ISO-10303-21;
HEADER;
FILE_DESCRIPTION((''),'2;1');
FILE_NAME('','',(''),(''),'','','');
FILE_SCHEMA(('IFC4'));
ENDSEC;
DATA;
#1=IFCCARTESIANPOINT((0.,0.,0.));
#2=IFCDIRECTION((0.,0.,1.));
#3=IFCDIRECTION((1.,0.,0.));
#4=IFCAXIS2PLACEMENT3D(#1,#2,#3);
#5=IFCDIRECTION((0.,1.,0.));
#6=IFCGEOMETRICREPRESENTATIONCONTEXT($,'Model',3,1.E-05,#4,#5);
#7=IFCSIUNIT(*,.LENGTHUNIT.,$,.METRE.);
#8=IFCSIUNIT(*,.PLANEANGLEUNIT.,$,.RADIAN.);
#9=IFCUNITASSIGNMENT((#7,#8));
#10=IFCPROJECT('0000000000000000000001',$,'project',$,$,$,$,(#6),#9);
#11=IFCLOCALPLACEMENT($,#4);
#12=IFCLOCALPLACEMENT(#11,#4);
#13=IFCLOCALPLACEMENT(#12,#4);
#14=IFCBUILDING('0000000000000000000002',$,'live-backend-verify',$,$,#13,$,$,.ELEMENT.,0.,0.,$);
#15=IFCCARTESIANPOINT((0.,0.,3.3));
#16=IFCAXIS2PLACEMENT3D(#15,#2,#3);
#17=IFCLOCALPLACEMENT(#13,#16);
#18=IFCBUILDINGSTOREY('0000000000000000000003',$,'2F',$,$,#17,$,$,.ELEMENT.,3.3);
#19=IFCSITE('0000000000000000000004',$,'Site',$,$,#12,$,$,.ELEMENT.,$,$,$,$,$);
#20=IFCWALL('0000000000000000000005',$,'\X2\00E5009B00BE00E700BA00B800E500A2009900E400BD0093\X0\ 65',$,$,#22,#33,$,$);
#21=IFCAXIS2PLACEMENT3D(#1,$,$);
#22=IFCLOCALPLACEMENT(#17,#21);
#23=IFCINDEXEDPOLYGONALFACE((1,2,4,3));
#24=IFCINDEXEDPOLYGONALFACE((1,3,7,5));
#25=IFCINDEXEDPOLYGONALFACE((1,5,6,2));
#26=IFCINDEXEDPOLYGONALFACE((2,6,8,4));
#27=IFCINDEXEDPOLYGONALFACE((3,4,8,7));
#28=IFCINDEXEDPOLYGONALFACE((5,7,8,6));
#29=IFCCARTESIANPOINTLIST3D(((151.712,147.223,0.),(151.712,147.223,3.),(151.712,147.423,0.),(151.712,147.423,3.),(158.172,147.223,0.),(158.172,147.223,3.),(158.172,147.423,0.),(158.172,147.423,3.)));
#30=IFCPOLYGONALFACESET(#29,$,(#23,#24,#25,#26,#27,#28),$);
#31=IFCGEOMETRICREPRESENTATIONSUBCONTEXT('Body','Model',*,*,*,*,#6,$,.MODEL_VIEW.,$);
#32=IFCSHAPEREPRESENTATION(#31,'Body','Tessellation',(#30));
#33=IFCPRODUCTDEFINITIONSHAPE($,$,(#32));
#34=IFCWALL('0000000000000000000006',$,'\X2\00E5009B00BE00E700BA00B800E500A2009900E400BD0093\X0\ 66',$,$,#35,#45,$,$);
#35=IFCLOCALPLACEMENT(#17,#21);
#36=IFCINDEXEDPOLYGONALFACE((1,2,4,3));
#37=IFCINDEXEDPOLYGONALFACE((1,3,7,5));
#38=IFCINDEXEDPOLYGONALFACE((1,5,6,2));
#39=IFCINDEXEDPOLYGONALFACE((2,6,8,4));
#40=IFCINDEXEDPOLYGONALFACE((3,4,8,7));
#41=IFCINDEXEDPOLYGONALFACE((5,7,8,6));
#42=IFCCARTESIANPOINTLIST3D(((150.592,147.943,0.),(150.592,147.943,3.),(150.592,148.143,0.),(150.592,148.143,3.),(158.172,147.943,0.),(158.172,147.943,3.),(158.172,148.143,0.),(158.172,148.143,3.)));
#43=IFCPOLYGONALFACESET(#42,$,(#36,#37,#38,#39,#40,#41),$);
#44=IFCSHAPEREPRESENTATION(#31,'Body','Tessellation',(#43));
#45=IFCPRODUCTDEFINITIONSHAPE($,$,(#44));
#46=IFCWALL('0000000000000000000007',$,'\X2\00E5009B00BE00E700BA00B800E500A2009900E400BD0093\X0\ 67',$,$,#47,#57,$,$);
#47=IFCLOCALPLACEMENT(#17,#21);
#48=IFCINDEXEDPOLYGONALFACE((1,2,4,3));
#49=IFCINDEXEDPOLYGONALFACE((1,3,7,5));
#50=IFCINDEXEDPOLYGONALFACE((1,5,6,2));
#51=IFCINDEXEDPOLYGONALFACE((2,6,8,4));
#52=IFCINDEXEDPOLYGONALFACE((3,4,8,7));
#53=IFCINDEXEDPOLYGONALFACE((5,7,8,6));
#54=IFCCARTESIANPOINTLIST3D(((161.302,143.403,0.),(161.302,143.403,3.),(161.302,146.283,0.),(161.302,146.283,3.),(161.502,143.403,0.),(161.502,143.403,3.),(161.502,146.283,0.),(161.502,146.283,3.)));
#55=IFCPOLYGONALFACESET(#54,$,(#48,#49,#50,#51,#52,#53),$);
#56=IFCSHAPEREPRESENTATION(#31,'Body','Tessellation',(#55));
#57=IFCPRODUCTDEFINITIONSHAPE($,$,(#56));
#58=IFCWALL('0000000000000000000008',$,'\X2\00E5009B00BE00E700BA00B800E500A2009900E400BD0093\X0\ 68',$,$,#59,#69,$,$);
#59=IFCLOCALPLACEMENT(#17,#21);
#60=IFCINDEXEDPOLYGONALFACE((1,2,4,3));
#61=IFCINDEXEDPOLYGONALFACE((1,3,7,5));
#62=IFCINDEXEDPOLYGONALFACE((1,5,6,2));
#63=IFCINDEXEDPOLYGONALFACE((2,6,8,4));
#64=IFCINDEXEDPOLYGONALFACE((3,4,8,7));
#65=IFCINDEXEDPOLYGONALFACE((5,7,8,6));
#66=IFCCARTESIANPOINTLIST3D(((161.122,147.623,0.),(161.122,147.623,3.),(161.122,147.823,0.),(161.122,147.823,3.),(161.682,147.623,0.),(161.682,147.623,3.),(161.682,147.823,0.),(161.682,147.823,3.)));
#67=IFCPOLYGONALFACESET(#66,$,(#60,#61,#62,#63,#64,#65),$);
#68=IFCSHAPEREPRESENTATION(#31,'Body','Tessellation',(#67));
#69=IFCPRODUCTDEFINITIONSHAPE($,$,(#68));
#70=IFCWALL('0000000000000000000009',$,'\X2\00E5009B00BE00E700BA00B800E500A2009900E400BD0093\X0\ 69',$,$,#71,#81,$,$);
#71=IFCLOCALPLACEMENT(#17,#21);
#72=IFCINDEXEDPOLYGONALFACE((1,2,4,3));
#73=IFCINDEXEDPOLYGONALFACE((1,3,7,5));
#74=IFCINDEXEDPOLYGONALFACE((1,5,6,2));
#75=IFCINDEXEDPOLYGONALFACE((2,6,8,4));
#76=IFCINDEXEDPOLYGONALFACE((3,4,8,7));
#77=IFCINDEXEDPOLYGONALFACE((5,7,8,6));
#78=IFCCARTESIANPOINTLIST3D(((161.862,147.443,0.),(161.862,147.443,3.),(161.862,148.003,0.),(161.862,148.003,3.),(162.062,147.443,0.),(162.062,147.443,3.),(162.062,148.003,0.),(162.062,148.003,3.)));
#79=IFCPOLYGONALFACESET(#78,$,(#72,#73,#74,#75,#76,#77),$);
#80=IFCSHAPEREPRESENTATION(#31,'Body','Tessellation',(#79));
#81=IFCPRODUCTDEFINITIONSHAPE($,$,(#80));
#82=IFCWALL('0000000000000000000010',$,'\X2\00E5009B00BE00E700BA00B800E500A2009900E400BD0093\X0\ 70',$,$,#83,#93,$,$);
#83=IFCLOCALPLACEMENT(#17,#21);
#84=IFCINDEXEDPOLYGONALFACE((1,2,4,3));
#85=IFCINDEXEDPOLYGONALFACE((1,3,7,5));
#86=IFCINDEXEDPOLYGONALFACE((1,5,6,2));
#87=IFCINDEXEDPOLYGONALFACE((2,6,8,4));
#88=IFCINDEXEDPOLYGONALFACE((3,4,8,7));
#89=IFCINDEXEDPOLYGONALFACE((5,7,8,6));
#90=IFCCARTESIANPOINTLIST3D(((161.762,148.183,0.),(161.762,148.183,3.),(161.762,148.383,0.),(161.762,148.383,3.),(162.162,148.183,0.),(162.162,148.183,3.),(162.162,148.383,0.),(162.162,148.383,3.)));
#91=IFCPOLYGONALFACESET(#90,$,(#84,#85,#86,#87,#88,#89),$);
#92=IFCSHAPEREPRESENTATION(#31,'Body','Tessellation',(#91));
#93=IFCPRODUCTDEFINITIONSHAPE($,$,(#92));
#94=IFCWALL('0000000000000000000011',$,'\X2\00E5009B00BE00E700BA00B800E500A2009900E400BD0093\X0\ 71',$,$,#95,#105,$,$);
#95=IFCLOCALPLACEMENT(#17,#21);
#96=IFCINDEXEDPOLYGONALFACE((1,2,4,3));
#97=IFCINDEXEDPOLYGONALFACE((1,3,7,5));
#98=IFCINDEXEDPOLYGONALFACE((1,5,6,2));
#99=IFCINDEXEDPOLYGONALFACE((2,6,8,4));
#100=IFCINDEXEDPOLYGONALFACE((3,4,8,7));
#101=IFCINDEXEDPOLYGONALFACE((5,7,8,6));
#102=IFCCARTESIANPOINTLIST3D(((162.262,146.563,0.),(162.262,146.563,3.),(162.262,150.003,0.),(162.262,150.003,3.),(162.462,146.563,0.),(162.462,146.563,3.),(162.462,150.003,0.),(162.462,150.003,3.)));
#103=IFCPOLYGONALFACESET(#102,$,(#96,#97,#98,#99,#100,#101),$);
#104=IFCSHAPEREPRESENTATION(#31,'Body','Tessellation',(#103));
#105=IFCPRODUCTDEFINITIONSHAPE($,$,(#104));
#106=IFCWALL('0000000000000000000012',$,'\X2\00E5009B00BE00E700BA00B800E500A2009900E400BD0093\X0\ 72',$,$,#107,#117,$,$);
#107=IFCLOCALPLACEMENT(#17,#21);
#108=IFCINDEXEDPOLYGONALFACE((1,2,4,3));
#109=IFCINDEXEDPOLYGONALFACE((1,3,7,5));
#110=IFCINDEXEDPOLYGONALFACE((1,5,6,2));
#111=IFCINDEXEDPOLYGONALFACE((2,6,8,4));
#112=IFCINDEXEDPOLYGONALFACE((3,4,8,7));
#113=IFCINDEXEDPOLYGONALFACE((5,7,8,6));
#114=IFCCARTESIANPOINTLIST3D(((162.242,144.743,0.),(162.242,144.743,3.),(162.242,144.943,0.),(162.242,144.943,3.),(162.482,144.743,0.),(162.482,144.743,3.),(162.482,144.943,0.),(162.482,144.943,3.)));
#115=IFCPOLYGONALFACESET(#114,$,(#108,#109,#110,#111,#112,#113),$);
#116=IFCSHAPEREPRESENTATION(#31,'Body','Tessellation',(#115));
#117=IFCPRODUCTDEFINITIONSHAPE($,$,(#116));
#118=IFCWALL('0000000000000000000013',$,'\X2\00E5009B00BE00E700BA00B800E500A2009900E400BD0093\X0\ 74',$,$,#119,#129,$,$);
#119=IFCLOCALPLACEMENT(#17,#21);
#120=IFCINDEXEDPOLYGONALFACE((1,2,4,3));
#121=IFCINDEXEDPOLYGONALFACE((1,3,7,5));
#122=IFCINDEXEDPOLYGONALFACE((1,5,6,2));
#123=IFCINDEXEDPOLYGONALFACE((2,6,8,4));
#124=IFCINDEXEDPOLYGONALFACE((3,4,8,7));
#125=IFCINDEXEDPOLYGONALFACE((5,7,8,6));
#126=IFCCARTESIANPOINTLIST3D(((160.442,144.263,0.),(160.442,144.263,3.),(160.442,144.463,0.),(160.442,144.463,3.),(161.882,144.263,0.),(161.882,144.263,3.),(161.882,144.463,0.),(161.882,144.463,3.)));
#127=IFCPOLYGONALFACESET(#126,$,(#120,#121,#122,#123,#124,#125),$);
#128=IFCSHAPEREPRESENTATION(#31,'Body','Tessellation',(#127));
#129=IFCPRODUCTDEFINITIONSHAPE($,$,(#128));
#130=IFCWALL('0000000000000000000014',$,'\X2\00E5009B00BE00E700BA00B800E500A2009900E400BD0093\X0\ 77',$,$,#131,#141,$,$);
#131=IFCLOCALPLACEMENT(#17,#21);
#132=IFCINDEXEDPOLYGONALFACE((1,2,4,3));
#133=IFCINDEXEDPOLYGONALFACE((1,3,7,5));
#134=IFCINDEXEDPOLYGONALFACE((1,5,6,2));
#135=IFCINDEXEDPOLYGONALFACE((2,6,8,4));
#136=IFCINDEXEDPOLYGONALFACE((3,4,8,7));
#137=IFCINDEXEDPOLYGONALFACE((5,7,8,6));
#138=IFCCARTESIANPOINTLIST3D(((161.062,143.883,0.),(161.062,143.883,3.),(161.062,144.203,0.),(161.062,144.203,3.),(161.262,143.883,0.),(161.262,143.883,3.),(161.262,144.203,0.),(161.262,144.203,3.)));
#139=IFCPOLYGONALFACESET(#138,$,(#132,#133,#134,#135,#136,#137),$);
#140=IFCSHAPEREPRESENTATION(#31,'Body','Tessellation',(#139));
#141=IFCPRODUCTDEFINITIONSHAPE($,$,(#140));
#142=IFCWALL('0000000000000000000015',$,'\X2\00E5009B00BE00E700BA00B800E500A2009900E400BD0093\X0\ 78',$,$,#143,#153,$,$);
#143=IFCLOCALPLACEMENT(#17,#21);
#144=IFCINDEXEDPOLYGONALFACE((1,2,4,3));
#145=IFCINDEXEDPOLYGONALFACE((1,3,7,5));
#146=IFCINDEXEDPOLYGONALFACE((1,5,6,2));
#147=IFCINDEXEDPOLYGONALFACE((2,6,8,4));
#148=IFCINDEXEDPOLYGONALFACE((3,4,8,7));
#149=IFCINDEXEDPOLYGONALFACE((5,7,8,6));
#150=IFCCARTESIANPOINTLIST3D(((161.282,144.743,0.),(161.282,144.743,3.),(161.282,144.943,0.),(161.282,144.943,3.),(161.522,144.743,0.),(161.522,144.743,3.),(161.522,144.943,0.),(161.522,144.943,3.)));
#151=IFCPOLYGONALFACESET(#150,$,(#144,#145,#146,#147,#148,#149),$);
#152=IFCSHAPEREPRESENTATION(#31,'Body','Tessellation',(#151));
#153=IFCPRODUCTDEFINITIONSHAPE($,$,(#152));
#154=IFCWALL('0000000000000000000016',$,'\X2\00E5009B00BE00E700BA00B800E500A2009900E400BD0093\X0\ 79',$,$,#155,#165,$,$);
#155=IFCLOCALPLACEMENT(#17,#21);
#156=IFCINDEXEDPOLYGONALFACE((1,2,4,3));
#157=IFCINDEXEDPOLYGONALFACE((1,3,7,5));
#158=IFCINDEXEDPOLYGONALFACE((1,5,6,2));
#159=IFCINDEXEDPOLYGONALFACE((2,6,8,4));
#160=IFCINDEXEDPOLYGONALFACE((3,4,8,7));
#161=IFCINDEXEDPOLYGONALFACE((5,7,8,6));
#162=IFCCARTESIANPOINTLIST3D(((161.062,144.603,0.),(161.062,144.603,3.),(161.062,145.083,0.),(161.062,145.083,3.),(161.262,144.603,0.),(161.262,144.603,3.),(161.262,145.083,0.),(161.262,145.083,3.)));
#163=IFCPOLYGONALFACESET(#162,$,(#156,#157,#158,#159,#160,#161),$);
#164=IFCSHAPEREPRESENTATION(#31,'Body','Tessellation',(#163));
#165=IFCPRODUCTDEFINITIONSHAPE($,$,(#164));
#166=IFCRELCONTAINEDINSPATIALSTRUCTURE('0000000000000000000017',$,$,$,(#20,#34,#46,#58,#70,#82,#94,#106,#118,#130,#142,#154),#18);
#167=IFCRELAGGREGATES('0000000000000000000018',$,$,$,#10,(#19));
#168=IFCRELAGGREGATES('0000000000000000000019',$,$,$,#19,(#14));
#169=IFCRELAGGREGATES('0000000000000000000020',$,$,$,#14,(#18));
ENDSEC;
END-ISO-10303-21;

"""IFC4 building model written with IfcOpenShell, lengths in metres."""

from ifc_helpers import new_model, si_unit, direction, frame, frame_2d, origin_with_axes, place, context, subcontext, project, spatial, rectangle, extrude, element, save


model = new_model("IFC4")

# Units and contexts
model_context = context("Model", 3, precision=1e-05, world=origin_with_axes(), true_north=direction((0.0, 1.0, 0.0)))
body_context = subcontext(model_context, "Body", "Model", "MODEL_VIEW")
ifc_project = project(units=[si_unit("LENGTHUNIT", "METRE"), si_unit("PLANEANGLEUNIT", "RADIAN")], contexts=[model_context])

# Site, building, storey
placement = place(None, origin_with_axes())
site_placement = place(placement, origin_with_axes())
site = spatial("IfcSite", under=ifc_project, at=site_placement, Name="Site", CompositionType="ELEMENT")
building_placement = place(site_placement, origin_with_axes())
building = spatial("IfcBuilding", under=site, at=building_placement, Name="live-backend-verify", CompositionType="ELEMENT", ElevationOfRefHeight=0.0, ElevationOfTerrain=0.0)
storey_placement = place(building_placement, frame((0.0, 0.0, 3.3), z_axis=(0.0, 0.0, 1.0), x_axis=(1.0, 0.0, 0.0)))
storey = spatial("IfcBuildingStorey", under=building, at=storey_placement, Name="2F", CompositionType="ELEMENT", Elevation=3.3)

# Walls
wall_1_placement = place(storey_placement, frame((154.942, 147.323, 0.0), z_axis=(0.0, 0.0, 1.0), x_axis=(1.0, 0.0, 0.0)))
element("IfcWall", 1, at=wall_1_placement, inside=storey, Name="å\u009b¾çº¸å¢\u0099ä½\u0093 65", context=body_context, shape_type="SweptSolid", body=[
    extrude(rectangle(XDim=6.46, YDim=0.2, at=frame_2d((0.0, 0.0), x_axis=(1.0, 0.0, 0.0))), frame((0.0, 0.0, 0.0), z_axis=(0.0, 0.0, 1.0)), (0.0, 0.0, 1.0), 3.0),
])
wall_2_placement = place(storey_placement, frame((154.382, 148.043, 0.0), z_axis=(0.0, 0.0, 1.0), x_axis=(1.0, 0.0, 0.0)))
element("IfcWall", 2, at=wall_2_placement, inside=storey, Name="å\u009b¾çº¸å¢\u0099ä½\u0093 66", context=body_context, shape_type="SweptSolid", body=[
    extrude(rectangle(XDim=7.58, YDim=0.2, at=frame_2d((0.0, 0.0), x_axis=(1.0, 0.0, 0.0))), frame((0.0, 0.0, 0.0), z_axis=(0.0, 0.0, 1.0)), (0.0, 0.0, 1.0), 3.0),
])
wall_3_placement = place(storey_placement, frame((161.402, 144.843, 0.0), z_axis=(0.0, 0.0, 1.0), x_axis=(0.0, 1.0, 0.0)))
element("IfcWall", 3, at=wall_3_placement, inside=storey, Name="å\u009b¾çº¸å¢\u0099ä½\u0093 67", context=body_context, shape_type="SweptSolid", body=[
    extrude(rectangle(XDim=2.88, YDim=0.2, at=frame_2d((0.0, 0.0), x_axis=(1.0, 0.0, 0.0))), frame((0.0, 0.0, 0.0), z_axis=(0.0, 0.0, 1.0)), (0.0, 0.0, 1.0), 3.0),
])
for number, where, z_axis, x_axis, name in (
    (4, (161.402, 147.723, 0.0), (0.0, 0.0, 1.0), (1.0, 0.0, 0.0), "å\u009b¾çº¸å¢\u0099ä½\u0093 68"),
    (5, (161.962, 147.723, 0.0), (0.0, 0.0, 1.0), (0.0, 1.0, 0.0), "å\u009b¾çº¸å¢\u0099ä½\u0093 69"),
):
    element("IfcWall", number, at=place(storey_placement, frame(where, z_axis=z_axis, x_axis=x_axis)), inside=storey, Name=name, context=body_context, shape_type="SweptSolid", body=[
        extrude(rectangle(XDim=0.56, YDim=0.2, at=frame_2d((0.0, 0.0), x_axis=(1.0, 0.0, 0.0))), frame((0.0, 0.0, 0.0), z_axis=(0.0, 0.0, 1.0)), (0.0, 0.0, 1.0), 3.0),
    ])
wall_4_placement = place(storey_placement, frame((161.962, 148.283, 0.0), z_axis=(0.0, 0.0, 1.0), x_axis=(1.0, 0.0, 0.0)))
element("IfcWall", 6, at=wall_4_placement, inside=storey, Name="å\u009b¾çº¸å¢\u0099ä½\u0093 70", context=body_context, shape_type="SweptSolid", body=[
    extrude(rectangle(XDim=0.4, YDim=0.2, at=frame_2d((0.0, 0.0), x_axis=(1.0, 0.0, 0.0))), frame((0.0, 0.0, 0.0), z_axis=(0.0, 0.0, 1.0)), (0.0, 0.0, 1.0), 3.0),
])
wall_5_placement = place(storey_placement, frame((162.362, 148.283, 0.0), z_axis=(0.0, 0.0, 1.0), x_axis=(0.0, -1.0, 0.0)))
element("IfcWall", 7, at=wall_5_placement, inside=storey, Name="å\u009b¾çº¸å¢\u0099ä½\u0093 71", context=body_context, shape_type="SweptSolid", body=[
    extrude(rectangle(XDim=3.44, YDim=0.2, at=frame_2d((0.0, 0.0), x_axis=(1.0, 0.0, 0.0))), frame((0.0, 0.0, 0.0), z_axis=(0.0, 0.0, 1.0)), (0.0, 0.0, 1.0), 3.0),
])
wall_6_placement = place(storey_placement, frame((162.362, 144.843, 0.0), z_axis=(0.0, 0.0, 1.0), x_axis=(1.0, 0.0, 0.0)))
element("IfcWall", 8, at=wall_6_placement, inside=storey, Name="å\u009b¾çº¸å¢\u0099ä½\u0093 72", context=body_context, shape_type="SweptSolid", body=[
    extrude(rectangle(XDim=0.24, YDim=0.2, at=frame_2d((0.0, 0.0), x_axis=(1.0, 0.0, 0.0))), frame((0.0, 0.0, 0.0), z_axis=(0.0, 0.0, 1.0)), (0.0, 0.0, 1.0), 3.0),
])
wall_7_placement = place(storey_placement, frame((161.162, 144.363, 0.0), z_axis=(0.0, 0.0, 1.0), x_axis=(1.0, 0.0, 0.0)))
element("IfcWall", 9, at=wall_7_placement, inside=storey, Name="å\u009b¾çº¸å¢\u0099ä½\u0093 74", context=body_context, shape_type="SweptSolid", body=[
    extrude(rectangle(XDim=1.44, YDim=0.2, at=frame_2d((0.0, 0.0), x_axis=(1.0, 0.0, 0.0))), frame((0.0, 0.0, 0.0), z_axis=(0.0, 0.0, 1.0)), (0.0, 0.0, 1.0), 3.0),
])
wall_8_placement = place(storey_placement, frame((161.162, 144.043, 0.0), z_axis=(0.0, 0.0, 1.0), x_axis=(0.0, 1.0, 0.0)))
element("IfcWall", 10, at=wall_8_placement, inside=storey, Name="å\u009b¾çº¸å¢\u0099ä½\u0093 77", context=body_context, shape_type="SweptSolid", body=[
    extrude(rectangle(XDim=0.32, YDim=0.2, at=frame_2d((0.0, 0.0), x_axis=(1.0, 0.0, 0.0))), frame((0.0, 0.0, 0.0), z_axis=(0.0, 0.0, 1.0)), (0.0, 0.0, 1.0), 3.0),
])
wall_9_placement = place(storey_placement, frame((161.402, 144.843, 0.0), z_axis=(0.0, 0.0, 1.0), x_axis=(-1.0, 0.0, 0.0)))
element("IfcWall", 11, at=wall_9_placement, inside=storey, Name="å\u009b¾çº¸å¢\u0099ä½\u0093 78", context=body_context, shape_type="SweptSolid", body=[
    extrude(rectangle(XDim=0.24, YDim=0.2, at=frame_2d((0.0, 0.0), x_axis=(1.0, 0.0, 0.0))), frame((0.0, 0.0, 0.0), z_axis=(0.0, 0.0, 1.0)), (0.0, 0.0, 1.0), 3.0),
])
wall_10_placement = place(storey_placement, frame((161.162, 144.843, 0.0), z_axis=(0.0, 0.0, 1.0), x_axis=(0.0, -1.0, 0.0)))
element("IfcWall", 12, at=wall_10_placement, inside=storey, Name="å\u009b¾çº¸å¢\u0099ä½\u0093 79", context=body_context, shape_type="SweptSolid", body=[
    extrude(rectangle(XDim=0.48, YDim=0.2, at=frame_2d((0.0, 0.0), x_axis=(1.0, 0.0, 0.0))), frame((0.0, 0.0, 0.0), z_axis=(0.0, 0.0, 1.0)), (0.0, 0.0, 1.0), 3.0),
])

save(model, "model.ifc")
